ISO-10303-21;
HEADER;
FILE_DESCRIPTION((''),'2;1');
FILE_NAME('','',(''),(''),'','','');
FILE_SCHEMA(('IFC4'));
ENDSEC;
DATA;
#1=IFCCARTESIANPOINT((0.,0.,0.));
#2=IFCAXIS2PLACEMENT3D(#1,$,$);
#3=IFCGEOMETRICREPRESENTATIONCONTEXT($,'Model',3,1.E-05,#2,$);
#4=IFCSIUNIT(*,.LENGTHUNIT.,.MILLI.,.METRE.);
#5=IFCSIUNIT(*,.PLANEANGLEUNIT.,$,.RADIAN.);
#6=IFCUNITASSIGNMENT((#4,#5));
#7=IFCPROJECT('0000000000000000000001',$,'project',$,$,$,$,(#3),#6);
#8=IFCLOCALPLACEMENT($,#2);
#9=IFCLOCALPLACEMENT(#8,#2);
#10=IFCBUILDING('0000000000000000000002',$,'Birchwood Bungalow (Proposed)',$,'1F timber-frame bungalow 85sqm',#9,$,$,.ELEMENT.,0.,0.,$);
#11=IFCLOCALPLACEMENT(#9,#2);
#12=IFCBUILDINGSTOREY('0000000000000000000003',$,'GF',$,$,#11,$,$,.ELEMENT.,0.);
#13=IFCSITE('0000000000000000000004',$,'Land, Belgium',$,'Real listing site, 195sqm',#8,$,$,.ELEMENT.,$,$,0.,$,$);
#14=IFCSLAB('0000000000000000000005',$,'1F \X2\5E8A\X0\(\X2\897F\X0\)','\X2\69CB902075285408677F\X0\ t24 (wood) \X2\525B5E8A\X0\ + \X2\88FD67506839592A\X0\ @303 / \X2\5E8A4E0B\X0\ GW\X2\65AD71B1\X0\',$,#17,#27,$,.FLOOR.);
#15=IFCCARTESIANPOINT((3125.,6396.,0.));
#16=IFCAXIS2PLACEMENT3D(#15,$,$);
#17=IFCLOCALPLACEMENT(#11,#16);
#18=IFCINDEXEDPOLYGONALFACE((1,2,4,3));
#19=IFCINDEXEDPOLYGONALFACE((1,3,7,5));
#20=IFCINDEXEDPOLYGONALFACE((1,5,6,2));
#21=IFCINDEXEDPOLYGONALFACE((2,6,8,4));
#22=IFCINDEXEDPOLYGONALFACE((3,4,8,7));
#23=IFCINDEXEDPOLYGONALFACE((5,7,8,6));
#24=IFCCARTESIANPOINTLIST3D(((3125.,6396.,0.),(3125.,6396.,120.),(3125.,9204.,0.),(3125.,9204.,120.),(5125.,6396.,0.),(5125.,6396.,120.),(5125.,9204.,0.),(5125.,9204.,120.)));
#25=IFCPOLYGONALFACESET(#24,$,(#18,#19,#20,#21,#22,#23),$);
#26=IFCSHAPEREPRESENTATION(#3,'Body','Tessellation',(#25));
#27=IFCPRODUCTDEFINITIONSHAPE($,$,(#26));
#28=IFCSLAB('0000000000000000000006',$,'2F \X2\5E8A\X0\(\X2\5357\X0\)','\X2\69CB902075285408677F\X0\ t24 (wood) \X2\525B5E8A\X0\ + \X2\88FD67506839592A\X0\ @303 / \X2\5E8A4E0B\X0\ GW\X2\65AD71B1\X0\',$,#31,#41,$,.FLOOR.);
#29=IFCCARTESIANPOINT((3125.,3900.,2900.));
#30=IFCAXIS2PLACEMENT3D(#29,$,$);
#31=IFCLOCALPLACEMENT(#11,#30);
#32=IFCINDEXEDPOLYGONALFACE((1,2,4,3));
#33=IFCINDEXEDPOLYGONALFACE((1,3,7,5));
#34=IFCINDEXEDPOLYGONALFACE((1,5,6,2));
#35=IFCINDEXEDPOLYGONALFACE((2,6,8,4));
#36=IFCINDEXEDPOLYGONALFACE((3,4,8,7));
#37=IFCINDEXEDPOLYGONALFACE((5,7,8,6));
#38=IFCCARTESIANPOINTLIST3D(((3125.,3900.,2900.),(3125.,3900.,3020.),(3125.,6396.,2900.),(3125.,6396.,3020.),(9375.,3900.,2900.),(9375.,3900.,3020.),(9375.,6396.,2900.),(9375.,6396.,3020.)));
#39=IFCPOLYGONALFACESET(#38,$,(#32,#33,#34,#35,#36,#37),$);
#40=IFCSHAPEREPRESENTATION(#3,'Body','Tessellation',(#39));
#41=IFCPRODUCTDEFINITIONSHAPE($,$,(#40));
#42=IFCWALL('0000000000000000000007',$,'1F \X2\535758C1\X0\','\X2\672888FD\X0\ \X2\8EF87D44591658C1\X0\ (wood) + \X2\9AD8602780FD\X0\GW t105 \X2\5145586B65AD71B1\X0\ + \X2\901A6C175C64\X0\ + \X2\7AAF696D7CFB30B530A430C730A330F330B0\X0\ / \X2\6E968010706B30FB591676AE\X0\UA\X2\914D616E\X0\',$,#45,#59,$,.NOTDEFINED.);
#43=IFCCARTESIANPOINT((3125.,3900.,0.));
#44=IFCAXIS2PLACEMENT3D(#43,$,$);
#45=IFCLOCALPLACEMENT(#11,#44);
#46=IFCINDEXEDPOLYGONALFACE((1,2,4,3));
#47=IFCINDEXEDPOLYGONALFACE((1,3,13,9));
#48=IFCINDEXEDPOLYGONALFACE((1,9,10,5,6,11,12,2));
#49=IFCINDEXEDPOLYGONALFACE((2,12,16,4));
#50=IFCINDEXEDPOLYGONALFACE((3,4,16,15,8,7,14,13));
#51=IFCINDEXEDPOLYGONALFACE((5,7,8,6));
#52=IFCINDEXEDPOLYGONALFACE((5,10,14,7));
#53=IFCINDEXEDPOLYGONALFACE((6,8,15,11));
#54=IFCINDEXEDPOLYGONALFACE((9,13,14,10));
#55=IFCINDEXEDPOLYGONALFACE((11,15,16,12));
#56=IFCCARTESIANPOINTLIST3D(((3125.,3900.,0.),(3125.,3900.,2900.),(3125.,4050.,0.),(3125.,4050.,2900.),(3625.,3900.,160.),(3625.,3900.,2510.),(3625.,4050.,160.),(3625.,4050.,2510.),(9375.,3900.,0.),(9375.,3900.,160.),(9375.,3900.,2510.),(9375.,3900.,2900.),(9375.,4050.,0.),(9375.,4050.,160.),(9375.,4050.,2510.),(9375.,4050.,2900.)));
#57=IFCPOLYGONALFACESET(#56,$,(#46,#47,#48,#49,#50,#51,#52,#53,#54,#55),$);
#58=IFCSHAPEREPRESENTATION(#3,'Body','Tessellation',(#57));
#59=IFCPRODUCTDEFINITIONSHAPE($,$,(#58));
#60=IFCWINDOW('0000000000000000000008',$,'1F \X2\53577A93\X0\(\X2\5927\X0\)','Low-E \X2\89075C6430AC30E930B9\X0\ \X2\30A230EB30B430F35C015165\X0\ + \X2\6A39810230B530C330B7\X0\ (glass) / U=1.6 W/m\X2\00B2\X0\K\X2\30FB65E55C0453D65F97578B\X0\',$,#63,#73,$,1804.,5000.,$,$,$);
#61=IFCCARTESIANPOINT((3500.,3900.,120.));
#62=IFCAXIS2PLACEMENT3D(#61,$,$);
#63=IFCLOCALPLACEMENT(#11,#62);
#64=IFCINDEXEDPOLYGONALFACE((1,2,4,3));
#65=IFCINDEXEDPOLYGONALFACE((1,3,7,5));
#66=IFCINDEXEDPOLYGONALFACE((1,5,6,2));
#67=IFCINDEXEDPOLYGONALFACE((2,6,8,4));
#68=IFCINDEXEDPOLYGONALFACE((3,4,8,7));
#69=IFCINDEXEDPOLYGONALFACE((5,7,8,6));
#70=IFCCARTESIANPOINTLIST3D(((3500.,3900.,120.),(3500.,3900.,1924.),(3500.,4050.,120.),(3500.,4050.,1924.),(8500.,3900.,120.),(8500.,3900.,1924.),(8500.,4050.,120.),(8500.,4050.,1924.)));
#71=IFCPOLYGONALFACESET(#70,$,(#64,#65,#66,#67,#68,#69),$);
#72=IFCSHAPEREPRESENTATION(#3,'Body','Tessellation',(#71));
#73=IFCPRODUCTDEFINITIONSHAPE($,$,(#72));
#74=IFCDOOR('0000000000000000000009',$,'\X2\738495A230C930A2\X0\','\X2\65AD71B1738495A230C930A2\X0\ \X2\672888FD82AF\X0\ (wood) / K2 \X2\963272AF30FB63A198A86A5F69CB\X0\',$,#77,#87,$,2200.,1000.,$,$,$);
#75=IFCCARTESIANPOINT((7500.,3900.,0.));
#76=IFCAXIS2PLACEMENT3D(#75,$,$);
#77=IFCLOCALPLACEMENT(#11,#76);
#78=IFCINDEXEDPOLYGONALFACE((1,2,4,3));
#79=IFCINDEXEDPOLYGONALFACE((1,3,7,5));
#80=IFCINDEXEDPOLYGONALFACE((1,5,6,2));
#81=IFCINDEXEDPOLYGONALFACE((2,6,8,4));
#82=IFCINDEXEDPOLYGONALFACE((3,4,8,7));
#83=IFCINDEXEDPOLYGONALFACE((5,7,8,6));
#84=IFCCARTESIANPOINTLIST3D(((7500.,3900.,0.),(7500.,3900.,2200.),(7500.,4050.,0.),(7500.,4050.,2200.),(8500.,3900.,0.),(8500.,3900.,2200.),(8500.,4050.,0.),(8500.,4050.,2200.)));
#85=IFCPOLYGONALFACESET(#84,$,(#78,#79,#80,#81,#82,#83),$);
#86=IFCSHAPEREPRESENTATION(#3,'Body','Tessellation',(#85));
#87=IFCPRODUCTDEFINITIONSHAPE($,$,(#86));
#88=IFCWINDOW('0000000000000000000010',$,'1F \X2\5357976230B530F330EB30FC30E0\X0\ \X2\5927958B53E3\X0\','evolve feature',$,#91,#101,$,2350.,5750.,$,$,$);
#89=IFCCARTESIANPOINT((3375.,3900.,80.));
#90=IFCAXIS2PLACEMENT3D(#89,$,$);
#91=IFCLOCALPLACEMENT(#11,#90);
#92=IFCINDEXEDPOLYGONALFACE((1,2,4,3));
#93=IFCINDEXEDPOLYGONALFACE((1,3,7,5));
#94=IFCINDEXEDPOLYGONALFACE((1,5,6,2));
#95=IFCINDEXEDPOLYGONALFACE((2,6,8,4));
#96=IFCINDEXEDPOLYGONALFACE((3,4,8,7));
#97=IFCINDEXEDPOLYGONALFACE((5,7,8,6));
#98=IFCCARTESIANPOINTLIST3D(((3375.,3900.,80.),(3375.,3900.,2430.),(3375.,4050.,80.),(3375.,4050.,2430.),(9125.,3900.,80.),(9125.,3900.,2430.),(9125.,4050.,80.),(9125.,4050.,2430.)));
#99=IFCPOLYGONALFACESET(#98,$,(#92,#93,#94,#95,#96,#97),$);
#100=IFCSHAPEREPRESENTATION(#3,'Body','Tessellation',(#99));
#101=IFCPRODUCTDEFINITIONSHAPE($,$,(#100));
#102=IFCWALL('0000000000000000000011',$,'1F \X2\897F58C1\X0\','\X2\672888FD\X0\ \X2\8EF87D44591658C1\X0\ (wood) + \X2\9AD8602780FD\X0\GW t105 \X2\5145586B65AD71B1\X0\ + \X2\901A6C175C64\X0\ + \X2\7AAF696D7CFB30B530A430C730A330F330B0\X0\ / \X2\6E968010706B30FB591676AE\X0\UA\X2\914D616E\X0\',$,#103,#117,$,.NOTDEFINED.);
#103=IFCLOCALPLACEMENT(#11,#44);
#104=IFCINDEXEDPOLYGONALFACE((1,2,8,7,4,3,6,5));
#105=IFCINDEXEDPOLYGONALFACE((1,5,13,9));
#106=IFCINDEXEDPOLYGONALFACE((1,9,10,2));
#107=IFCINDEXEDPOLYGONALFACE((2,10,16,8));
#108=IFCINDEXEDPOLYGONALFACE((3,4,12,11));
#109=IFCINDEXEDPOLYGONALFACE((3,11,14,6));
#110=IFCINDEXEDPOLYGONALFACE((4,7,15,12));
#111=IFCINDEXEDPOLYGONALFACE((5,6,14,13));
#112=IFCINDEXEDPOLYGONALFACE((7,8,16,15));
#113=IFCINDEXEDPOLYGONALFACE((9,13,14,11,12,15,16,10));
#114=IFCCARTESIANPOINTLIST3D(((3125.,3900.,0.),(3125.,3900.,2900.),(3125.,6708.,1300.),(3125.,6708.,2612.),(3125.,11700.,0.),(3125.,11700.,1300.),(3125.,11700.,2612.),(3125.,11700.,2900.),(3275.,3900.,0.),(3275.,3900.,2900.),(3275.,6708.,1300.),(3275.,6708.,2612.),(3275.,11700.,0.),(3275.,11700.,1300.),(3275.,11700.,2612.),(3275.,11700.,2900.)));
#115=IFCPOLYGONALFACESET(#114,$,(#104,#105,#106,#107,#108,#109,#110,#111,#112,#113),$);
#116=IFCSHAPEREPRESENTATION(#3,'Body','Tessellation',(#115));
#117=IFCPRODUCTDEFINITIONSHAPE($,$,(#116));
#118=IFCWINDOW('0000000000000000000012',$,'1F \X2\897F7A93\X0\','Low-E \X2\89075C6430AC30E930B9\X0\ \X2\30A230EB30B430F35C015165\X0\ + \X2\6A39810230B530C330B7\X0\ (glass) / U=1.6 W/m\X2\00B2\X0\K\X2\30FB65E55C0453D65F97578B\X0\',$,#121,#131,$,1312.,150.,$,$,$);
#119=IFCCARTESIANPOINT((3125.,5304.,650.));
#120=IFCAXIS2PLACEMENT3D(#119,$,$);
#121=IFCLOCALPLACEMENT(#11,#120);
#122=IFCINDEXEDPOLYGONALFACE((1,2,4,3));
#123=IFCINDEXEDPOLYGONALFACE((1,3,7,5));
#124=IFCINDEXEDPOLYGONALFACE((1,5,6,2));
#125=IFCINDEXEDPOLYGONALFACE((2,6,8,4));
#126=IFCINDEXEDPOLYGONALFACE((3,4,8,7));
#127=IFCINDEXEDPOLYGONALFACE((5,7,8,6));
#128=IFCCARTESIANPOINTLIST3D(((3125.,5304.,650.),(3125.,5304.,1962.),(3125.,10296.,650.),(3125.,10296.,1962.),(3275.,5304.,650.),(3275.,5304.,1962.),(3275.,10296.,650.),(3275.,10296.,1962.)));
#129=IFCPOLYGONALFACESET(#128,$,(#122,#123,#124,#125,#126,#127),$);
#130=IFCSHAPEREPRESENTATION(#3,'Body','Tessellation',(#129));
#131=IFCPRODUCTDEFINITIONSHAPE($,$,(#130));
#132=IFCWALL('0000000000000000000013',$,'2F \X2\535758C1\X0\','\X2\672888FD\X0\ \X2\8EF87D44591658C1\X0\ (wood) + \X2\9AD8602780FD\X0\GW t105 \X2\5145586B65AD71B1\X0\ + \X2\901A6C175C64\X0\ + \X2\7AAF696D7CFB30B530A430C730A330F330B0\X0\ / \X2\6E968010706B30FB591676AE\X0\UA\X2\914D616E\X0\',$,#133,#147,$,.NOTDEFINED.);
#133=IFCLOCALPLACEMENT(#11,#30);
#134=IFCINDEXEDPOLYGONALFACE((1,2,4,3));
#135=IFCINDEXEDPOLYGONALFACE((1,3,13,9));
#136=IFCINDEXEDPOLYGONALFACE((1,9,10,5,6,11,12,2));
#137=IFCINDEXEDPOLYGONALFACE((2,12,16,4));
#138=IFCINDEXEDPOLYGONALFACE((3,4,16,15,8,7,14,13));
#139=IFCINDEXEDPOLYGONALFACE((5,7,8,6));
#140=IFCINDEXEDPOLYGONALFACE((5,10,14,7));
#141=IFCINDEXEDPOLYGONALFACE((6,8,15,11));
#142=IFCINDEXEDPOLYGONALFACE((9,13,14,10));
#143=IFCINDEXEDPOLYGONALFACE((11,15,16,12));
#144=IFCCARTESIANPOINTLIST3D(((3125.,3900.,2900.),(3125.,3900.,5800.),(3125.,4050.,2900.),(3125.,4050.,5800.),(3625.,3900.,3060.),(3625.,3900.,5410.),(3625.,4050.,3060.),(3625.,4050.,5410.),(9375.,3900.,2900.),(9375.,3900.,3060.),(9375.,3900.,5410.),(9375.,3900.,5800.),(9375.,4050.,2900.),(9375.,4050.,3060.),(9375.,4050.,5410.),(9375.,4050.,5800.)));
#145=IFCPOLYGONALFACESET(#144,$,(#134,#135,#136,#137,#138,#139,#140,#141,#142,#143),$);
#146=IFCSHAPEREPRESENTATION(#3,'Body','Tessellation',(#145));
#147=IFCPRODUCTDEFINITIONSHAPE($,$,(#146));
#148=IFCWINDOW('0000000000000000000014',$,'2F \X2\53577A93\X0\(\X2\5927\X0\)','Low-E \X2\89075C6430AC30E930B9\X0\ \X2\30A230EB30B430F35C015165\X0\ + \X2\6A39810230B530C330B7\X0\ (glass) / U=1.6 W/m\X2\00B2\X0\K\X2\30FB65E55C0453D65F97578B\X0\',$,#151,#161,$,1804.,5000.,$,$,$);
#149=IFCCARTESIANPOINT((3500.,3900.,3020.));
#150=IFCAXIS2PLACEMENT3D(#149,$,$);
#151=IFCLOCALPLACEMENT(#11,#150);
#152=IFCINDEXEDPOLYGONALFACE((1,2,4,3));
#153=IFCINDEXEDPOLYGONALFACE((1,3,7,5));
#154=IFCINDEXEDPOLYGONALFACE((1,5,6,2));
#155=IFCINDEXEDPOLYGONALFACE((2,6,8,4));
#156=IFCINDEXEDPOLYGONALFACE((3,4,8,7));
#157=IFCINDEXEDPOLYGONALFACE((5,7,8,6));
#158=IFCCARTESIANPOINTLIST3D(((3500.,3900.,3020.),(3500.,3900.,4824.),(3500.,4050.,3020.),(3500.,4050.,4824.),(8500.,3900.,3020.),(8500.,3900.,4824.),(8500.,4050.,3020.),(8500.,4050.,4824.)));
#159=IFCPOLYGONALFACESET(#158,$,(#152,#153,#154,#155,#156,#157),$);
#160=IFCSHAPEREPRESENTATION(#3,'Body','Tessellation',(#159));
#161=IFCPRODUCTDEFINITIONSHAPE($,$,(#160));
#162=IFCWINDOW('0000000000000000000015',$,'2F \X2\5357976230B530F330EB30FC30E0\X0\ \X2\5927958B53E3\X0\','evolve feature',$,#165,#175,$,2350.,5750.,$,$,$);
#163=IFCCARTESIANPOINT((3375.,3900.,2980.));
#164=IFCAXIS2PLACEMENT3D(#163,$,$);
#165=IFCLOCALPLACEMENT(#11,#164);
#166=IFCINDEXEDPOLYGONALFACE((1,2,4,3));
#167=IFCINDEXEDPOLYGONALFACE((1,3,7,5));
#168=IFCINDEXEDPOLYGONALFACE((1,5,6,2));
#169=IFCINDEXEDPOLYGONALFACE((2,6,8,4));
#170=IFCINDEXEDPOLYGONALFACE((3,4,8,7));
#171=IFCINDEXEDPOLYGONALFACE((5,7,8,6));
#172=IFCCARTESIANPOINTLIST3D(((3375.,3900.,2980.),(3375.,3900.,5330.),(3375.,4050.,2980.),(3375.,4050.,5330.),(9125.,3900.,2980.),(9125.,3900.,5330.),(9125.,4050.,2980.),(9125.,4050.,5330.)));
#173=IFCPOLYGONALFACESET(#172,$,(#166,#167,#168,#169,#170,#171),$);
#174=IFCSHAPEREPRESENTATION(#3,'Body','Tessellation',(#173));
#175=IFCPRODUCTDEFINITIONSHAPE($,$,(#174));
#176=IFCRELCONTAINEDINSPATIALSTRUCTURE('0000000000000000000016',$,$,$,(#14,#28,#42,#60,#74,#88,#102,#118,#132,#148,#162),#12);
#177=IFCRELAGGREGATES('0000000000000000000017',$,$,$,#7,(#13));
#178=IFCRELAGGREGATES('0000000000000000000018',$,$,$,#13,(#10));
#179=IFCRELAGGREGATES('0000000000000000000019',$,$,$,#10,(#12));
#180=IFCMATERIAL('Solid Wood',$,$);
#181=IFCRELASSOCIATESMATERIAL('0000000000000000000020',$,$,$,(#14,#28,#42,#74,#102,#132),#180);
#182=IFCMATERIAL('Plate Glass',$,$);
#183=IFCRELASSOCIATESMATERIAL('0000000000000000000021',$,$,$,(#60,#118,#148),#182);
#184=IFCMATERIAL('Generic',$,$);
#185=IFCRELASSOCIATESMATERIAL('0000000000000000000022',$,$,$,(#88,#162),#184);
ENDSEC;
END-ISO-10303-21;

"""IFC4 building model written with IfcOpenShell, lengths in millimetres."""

from ifc_helpers import new_model, si_unit, frame, frame_2d, origin, place, context, project, spatial, rectangle, extrude, material, element, fill, save


model = new_model("IFC4")

# Units and contexts
model_context = context("Model", 3, precision=1e-05, world=origin())
ifc_project = project(units=[si_unit("LENGTHUNIT", "METRE", prefix="MILLI"), si_unit("PLANEANGLEUNIT", "RADIAN")], contexts=[model_context])

# Site, building, storey
site_placement = place(None, origin())
site = spatial("IfcSite", under=ifc_project, at=site_placement, Name="Land, Belgium", ObjectType="Real listing site, 195sqm", CompositionType="ELEMENT", RefElevation=0.0)
building_placement = place(site_placement, origin())
building = spatial("IfcBuilding", under=site, at=building_placement, Name="Birchwood Bungalow (Proposed)", ObjectType="1F timber-frame bungalow 85sqm", CompositionType="ELEMENT", ElevationOfRefHeight=0.0, ElevationOfTerrain=0.0)
storey_placement = place(building_placement, origin())
storey = spatial("IfcBuildingStorey", under=building, at=storey_placement, Name="GF", CompositionType="ELEMENT", Elevation=0.0)

# Slabs
ifc_material_1 = material(Name="Solid Wood")
slab_1_placement = place(storey_placement, frame((3125.0, 6396.0, 0.0)))
element("IfcSlab", 1, at=slab_1_placement, inside=storey, material=ifc_material_1, Name="1F 床(西)", Description="構造用合板 t24 (wood) 剛床 + 製材根太 @303 / 床下 GW断熱", PredefinedType="FLOOR", context=model_context, shape_type="SweptSolid", body=[
    extrude(rectangle(XDim=2000.0, YDim=2808.0, at=frame_2d((1000.0, 1404.0))), frame((3125.0, 6396.0, 0.0)), (0.0, 0.0, 1.0), 120.0),
])
slab_2_placement = place(storey_placement, frame((3125.0, 3900.0, 2900.0)))
element("IfcSlab", 2, at=slab_2_placement, inside=storey, material=ifc_material_1, Name="2F 床(南)", Description="構造用合板 t24 (wood) 剛床 + 製材根太 @303 / 床下 GW断熱", PredefinedType="FLOOR", context=model_context, shape_type="SweptSolid", body=[
    extrude(rectangle(XDim=6250.0, YDim=2496.0, at=frame_2d((3125.0, 1248.0))), frame((3125.0, 3900.0, 2900.0)), (0.0, 0.0, 1.0), 120.0),
])
ifc_material_2 = material(Name="Generic")

# Wall, openings, windows, door
wall_1_placement = place(storey_placement, frame((3125.0, 3900.0, 0.0)))
wall_1 = element("IfcWall", 3, at=wall_1_placement, inside=storey, material=ifc_material_1, Name="1F 南壁", Description="木製 軸組外壁 (wood) + 高性能GW t105 充填断熱 + 通気層 + 窯業系サイディング / 準耐火・外皮UA配慮", PredefinedType="NOTDEFINED", context=model_context, shape_type="SweptSolid", body=[
    extrude(rectangle(XDim=6250.0, YDim=150.0, at=frame_2d((3125.0, 75.0))), frame((3125.0, 3900.0, 0.0)), (0.0, 0.0, 1.0), 2900.0),
])
opening_1_placement = place(storey_placement, frame((3500.0, 3900.0, 120.0)))
opening_1 = element("IfcOpeningElement", 4, at=opening_1_placement, cuts=wall_1, PredefinedType="NOTDEFINED", context=model_context, shape_type="SweptSolid", body=[
    extrude(rectangle(XDim=5000.0, YDim=150.0, at=frame_2d((2500.0, 75.0))), frame((3500.0, 3900.0, 120.0)), (0.0, 0.0, 1.0), 1804.0),
])
opening_2_placement = place(storey_placement, frame((7500.0, 3900.0, 0.0)))
opening_2 = element("IfcOpeningElement", 5, at=opening_2_placement, cuts=wall_1, PredefinedType="NOTDEFINED", context=model_context, shape_type="SweptSolid", body=[
    extrude(rectangle(XDim=1000.0, YDim=150.0, at=frame_2d((500.0, 75.0))), frame((7500.0, 3900.0, 0.0)), (0.0, 0.0, 1.0), 2200.0),
])
opening_3_placement = place(storey_placement, frame((3375.0, 3900.0, 80.0)))
opening_3 = element("IfcOpeningElement", 6, at=opening_3_placement, cuts=wall_1, PredefinedType="NOTDEFINED", context=model_context, shape_type="SweptSolid", body=[
    extrude(rectangle(XDim=5750.0, YDim=150.0, at=frame_2d((2875.0, 75.0))), frame((3375.0, 3900.0, 80.0)), (0.0, 0.0, 1.0), 2350.0),
])
ifc_material_3 = material(Name="Plate Glass")
window_1_placement = place(storey_placement, frame((3500.0, 3900.0, 120.0)))
window_1 = element("IfcWindow", 7, at=window_1_placement, inside=storey, material=ifc_material_3, Name="1F 南窓(大)", Description="Low-E 複層ガラス アルゴン封入 + 樹脂サッシ (glass) / U=1.6 W/m²K・日射取得型", OverallHeight=1804.0, OverallWidth=5000.0, context=model_context, shape_type="SweptSolid", body=[
    extrude(rectangle(XDim=5000.0, YDim=150.0, at=frame_2d((2500.0, 75.0))), frame((3500.0, 3900.0, 120.0)), (0.0, 0.0, 1.0), 1804.0),
])
fill(opening_1, window_1)
door_placement = place(storey_placement, frame((7500.0, 3900.0, 0.0)))
door = element("IfcDoor", 8, at=door_placement, inside=storey, material=ifc_material_1, Name="玄関ドア", Description="断熱玄関ドア 木製芯 (wood) / K2 防犯・採風機構", OverallHeight=2200.0, OverallWidth=1000.0, context=model_context, shape_type="SweptSolid", body=[
    extrude(rectangle(XDim=1000.0, YDim=150.0, at=frame_2d((500.0, 75.0))), frame((7500.0, 3900.0, 0.0)), (0.0, 0.0, 1.0), 2200.0),
])
fill(opening_2, door)
window_2_placement = place(storey_placement, frame((3375.0, 3900.0, 80.0)))
window_2 = element("IfcWindow", 9, at=window_2_placement, inside=storey, material=ifc_material_2, Name="1F 南面サンルーム 大開口", Description="evolve feature", OverallHeight=2350.0, OverallWidth=5750.0, context=model_context, shape_type="SweptSolid", body=[
    extrude(rectangle(XDim=5750.0, YDim=150.0, at=frame_2d((2875.0, 75.0))), frame((3375.0, 3900.0, 80.0)), (0.0, 0.0, 1.0), 2350.0),
])
fill(opening_3, window_2)

# Wall, opening, window
wall_2_placement = place(storey_placement, frame((3125.0, 3900.0, 0.0)))
wall_2 = element("IfcWall", 10, at=wall_2_placement, inside=storey, material=ifc_material_1, Name="1F 西壁", Description="木製 軸組外壁 (wood) + 高性能GW t105 充填断熱 + 通気層 + 窯業系サイディング / 準耐火・外皮UA配慮", PredefinedType="NOTDEFINED", context=model_context, shape_type="SweptSolid", body=[
    extrude(rectangle(XDim=150.0, YDim=7800.0, at=frame_2d((75.0, 3900.0))), frame((3125.0, 3900.0, 0.0)), (0.0, 0.0, 1.0), 2900.0),
])
opening_4_placement = place(storey_placement, frame((3125.0, 5304.0, 650.0)))
opening_4 = element("IfcOpeningElement", 11, at=opening_4_placement, cuts=wall_2, PredefinedType="NOTDEFINED", context=model_context, shape_type="SweptSolid", body=[
    extrude(rectangle(XDim=150.0, YDim=4992.0, at=frame_2d((75.0, 2496.0))), frame((3125.0, 5304.0, 650.0)), (0.0, 0.0, 1.0), 1312.0),
])
window_3_placement = place(storey_placement, frame((3125.0, 5304.0, 650.0)))
window_3 = element("IfcWindow", 12, at=window_3_placement, inside=storey, material=ifc_material_3, Name="1F 西窓", Description="Low-E 複層ガラス アルゴン封入 + 樹脂サッシ (glass) / U=1.6 W/m²K・日射取得型", OverallHeight=1312.0, OverallWidth=150.0, context=model_context, shape_type="SweptSolid", body=[
    extrude(rectangle(XDim=150.0, YDim=4992.0, at=frame_2d((75.0, 2496.0))), frame((3125.0, 5304.0, 650.0)), (0.0, 0.0, 1.0), 1312.0),
])
fill(opening_4, window_3)

# Wall, openings, windows
wall_3_placement = place(storey_placement, frame((3125.0, 3900.0, 2900.0)))
wall_3 = element("IfcWall", 13, at=wall_3_placement, inside=storey, material=ifc_material_1, Name="2F 南壁", Description="木製 軸組外壁 (wood) + 高性能GW t105 充填断熱 + 通気層 + 窯業系サイディング / 準耐火・外皮UA配慮", PredefinedType="NOTDEFINED", context=model_context, shape_type="SweptSolid", body=[
    extrude(rectangle(XDim=6250.0, YDim=150.0, at=frame_2d((3125.0, 75.0))), frame((3125.0, 3900.0, 2900.0)), (0.0, 0.0, 1.0), 2900.0),
])
opening_5_placement = place(storey_placement, frame((3500.0, 3900.0, 3020.0)))
opening_5 = element("IfcOpeningElement", 14, at=opening_5_placement, cuts=wall_3, PredefinedType="NOTDEFINED", context=model_context, shape_type="SweptSolid", body=[
    extrude(rectangle(XDim=5000.0, YDim=150.0, at=frame_2d((2500.0, 75.0))), frame((3500.0, 3900.0, 3020.0)), (0.0, 0.0, 1.0), 1804.0),
])
opening_6_placement = place(storey_placement, frame((3375.0, 3900.0, 2980.0)))
opening_6 = element("IfcOpeningElement", 15, at=opening_6_placement, cuts=wall_3, PredefinedType="NOTDEFINED", context=model_context, shape_type="SweptSolid", body=[
    extrude(rectangle(XDim=5750.0, YDim=150.0, at=frame_2d((2875.0, 75.0))), frame((3375.0, 3900.0, 2980.0)), (0.0, 0.0, 1.0), 2350.0),
])
window_4_placement = place(storey_placement, frame((3500.0, 3900.0, 3020.0)))
window_4 = element("IfcWindow", 16, at=window_4_placement, inside=storey, material=ifc_material_3, Name="2F 南窓(大)", Description="Low-E 複層ガラス アルゴン封入 + 樹脂サッシ (glass) / U=1.6 W/m²K・日射取得型", OverallHeight=1804.0, OverallWidth=5000.0, context=model_context, shape_type="SweptSolid", body=[
    extrude(rectangle(XDim=5000.0, YDim=150.0, at=frame_2d((2500.0, 75.0))), frame((3500.0, 3900.0, 3020.0)), (0.0, 0.0, 1.0), 1804.0),
])
fill(opening_5, window_4)
window_5_placement = place(storey_placement, frame((3375.0, 3900.0, 2980.0)))
window_5 = element("IfcWindow", 17, at=window_5_placement, inside=storey, material=ifc_material_2, Name="2F 南面サンルーム 大開口", Description="evolve feature", OverallHeight=2350.0, OverallWidth=5750.0, context=model_context, shape_type="SweptSolid", body=[
    extrude(rectangle(XDim=5750.0, YDim=150.0, at=frame_2d((2875.0, 75.0))), frame((3375.0, 3900.0, 2980.0)), (0.0, 0.0, 1.0), 2350.0),
])
fill(opening_6, window_5)

save(model, "model.ifc")
